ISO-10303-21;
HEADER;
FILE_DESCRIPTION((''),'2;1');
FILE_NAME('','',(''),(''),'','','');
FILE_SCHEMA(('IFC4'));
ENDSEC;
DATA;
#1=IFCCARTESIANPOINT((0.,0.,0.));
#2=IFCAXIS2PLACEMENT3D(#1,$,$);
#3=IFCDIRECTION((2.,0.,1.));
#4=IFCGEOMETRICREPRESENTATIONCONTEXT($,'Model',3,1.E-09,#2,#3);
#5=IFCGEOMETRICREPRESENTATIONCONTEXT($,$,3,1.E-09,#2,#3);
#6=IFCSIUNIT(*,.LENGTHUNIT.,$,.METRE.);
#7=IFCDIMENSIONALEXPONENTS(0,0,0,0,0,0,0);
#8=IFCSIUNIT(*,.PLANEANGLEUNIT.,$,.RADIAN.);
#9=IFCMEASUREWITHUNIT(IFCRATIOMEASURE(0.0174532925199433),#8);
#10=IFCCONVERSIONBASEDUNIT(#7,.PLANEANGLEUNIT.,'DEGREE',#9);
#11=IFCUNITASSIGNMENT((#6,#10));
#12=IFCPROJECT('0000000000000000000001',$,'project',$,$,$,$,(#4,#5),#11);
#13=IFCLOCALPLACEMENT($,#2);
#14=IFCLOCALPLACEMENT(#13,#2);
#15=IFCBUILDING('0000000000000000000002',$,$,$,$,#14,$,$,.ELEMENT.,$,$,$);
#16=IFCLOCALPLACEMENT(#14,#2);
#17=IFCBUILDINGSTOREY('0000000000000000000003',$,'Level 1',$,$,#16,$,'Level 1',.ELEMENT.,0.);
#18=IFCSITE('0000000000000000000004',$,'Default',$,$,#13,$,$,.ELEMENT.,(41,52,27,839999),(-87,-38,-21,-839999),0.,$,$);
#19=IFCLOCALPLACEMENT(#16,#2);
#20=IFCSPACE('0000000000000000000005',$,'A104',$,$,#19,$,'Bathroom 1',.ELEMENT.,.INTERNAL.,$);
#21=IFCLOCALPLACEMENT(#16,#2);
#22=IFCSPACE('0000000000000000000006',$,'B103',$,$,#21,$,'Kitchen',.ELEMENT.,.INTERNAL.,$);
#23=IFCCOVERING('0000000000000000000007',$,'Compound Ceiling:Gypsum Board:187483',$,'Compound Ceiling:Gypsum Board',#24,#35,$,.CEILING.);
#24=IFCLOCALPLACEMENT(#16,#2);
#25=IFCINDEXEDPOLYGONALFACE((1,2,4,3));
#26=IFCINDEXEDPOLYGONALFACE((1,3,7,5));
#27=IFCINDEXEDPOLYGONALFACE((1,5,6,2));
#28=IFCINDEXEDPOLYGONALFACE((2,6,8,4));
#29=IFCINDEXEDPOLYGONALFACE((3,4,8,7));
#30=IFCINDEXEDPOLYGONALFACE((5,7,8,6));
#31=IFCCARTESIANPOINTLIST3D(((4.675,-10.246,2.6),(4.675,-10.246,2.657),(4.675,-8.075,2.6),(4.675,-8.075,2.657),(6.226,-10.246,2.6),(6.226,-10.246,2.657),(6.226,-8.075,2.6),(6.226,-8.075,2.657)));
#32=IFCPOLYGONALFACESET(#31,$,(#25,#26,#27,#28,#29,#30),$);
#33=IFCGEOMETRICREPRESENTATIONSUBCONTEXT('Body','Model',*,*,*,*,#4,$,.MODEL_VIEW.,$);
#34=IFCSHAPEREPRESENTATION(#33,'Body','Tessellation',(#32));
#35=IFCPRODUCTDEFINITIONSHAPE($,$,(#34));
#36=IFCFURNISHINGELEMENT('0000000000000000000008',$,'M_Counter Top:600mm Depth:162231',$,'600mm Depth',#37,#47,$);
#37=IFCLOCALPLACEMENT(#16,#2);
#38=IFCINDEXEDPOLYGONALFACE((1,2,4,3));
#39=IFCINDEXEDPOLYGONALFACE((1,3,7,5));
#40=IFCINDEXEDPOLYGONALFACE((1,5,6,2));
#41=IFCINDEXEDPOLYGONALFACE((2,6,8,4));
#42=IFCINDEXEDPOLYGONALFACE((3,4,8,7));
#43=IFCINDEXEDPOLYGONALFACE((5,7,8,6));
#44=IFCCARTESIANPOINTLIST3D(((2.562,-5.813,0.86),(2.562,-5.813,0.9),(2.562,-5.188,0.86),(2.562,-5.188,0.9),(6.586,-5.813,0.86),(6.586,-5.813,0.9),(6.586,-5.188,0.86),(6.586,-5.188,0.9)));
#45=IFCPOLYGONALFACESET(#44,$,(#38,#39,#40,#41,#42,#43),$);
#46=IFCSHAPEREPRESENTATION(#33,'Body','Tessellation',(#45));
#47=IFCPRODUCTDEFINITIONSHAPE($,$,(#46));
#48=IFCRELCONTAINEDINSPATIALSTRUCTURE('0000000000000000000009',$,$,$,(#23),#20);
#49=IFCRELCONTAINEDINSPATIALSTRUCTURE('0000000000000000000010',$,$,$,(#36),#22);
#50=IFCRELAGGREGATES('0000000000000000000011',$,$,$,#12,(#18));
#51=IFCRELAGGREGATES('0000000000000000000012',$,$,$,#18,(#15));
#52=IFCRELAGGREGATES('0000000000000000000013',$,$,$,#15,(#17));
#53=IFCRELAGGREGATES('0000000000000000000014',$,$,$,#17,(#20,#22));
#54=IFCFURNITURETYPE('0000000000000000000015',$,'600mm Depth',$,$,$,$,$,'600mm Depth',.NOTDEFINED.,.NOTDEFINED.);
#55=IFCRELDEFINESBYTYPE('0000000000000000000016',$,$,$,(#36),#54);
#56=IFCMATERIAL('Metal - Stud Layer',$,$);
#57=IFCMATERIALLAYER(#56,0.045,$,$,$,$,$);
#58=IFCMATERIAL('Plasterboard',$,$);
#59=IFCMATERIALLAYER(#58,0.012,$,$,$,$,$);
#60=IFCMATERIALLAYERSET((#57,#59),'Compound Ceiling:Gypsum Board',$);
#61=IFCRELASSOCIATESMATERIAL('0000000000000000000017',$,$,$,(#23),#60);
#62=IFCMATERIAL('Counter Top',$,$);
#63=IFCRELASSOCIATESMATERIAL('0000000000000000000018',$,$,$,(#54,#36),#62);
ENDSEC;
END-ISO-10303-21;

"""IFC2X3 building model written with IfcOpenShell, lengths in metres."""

from ifc_helpers import new_model, entity, si_unit, converted_unit, direction, frame, frame_2d, origin, place, context, subcontext, project, spatial, rectangle, extrude, source, transform, mapped, material, layer, layer_set, layer_usage, type_object, type_shapes, element, save


model = new_model("IFC2X3")

# Units and contexts
model_context = context("Model", 3, precision=1e-09, world=origin(), true_north=direction((2.0, 0.0, 1.0)))
context_of_model = context(None, 3, precision=1e-09, world=origin(), true_north=direction((2.0, 0.0, 1.0)))
body_context = subcontext(model_context, "Body", "Model", "MODEL_VIEW")
ifc_project = project(units=[si_unit("LENGTHUNIT", "METRE"), converted_unit("PLANEANGLEUNIT", "DEGREE", entity("IfcRatioMeasure", 0.0174532925199433), si_unit("PLANEANGLEUNIT", "RADIAN"), dimensions=[0, 0, 0, 0, 0, 0, 0])], contexts=[model_context, context_of_model])

# Site, building, storey
site_placement = place(None, origin())
site = spatial("IfcSite", under=ifc_project, at=site_placement, Name="Default", CompositionType="ELEMENT", RefLatitude=(41, 52, 27, 839999), RefLongitude=(-87, -38, -21, -839999), RefElevation=0.0)
building_placement = place(site_placement, origin())
building = spatial("IfcBuilding", under=site, at=building_placement, CompositionType="ELEMENT")
storey_placement = place(building_placement, origin())
storey = spatial("IfcBuildingStorey", under=building, at=storey_placement, Name="Level 1", LongName="Level 1", CompositionType="ELEMENT", Elevation=0.0)

# Shared definitions
ifc_material_1 = material(Name="Metal - Stud Layer")
ifc_material_2 = material(Name="Plasterboard")

# Shared definitions
ifc_layer_1 = layer(ifc_material_1, 0.045)
ifc_layer_2 = layer(ifc_material_2, 0.012)
ifc_layer_set_1 = layer_set([ifc_layer_1, ifc_layer_2], Name="Compound Ceiling:Gypsum Board")

# Shared definitions
space_1_placement = place(storey_placement, origin())
space_1 = spatial("IfcSpace", under=storey, at=space_1_placement, Name="A104", LongName="Bathroom 1", CompositionType="ELEMENT", InteriorOrExteriorSpace="INTERNAL")

# Covering
ifc_layer_usage_1 = layer_usage(ifc_layer_set_1, "AXIS3", "NEGATIVE", 0.0)
covering_1_placement = place(space_1_placement, origin())
element("IfcCovering", 1, at=covering_1_placement, inside=space_1, material=ifc_layer_usage_1, Name="Compound Ceiling:Gypsum Board:187483", ObjectType="Compound Ceiling:Gypsum Board", PredefinedType="CEILING", context=body_context, shape_type="SweptSolid", body=[
    extrude(rectangle(XDim=2.171, YDim=1.551, at=frame_2d((0.0, 0.0), x_axis=(1.0, 0.0))), frame((5.4505, -9.1605, 2.6), z_axis=(0.0, 0.0, 1.0), x_axis=(0.0, -1.0, 0.0)), (0.0, 0.0, 1.0), 0.057),
])

# Shared definitions
space_2_placement = place(storey_placement, origin())
space_2 = spatial("IfcSpace", under=storey, at=space_2_placement, Name="B103", LongName="Kitchen", CompositionType="ELEMENT", InteriorOrExteriorSpace="INTERNAL")

# Furnishing element
ifc_material_3 = material(Name="Counter Top")
furniture_type_1 = type_object("IfcFurnitureType", Name="600mm Depth", ElementType="600mm Depth", AssemblyPlace="NOTDEFINED", material=ifc_material_3)
shared_shape_1 = source(origin(), body_context, "Body", "SweptSolid", [
    extrude(rectangle(XDim=4.024, YDim=0.625, at=frame_2d((0.0, 0.0), x_axis=(1.0, 0.0))), frame((0.8115, -0.3125, 0.86), z_axis=(0.0, 0.0, 1.0), x_axis=(-1.0, 0.0, 0.0)), (0.0, 0.0, 1.0), 0.04),
])
type_shapes(furniture_type_1, [shared_shape_1])
furnishing_1_placement = place(space_2_placement, frame((3.7625, -5.188, 0.0)))
element("IfcFurnishingElement", 2, at=furnishing_1_placement, inside=space_2, type_object=furniture_type_1, material=ifc_material_3, Name="M_Counter Top:600mm Depth:162231", ObjectType="600mm Depth", context=body_context, shape_type="MappedRepresentation", body=[
    mapped(shared_shape_1, transform((0.0, 0.0, 0.0), scale=1.0)),
])

save(model, "model.ifc")
